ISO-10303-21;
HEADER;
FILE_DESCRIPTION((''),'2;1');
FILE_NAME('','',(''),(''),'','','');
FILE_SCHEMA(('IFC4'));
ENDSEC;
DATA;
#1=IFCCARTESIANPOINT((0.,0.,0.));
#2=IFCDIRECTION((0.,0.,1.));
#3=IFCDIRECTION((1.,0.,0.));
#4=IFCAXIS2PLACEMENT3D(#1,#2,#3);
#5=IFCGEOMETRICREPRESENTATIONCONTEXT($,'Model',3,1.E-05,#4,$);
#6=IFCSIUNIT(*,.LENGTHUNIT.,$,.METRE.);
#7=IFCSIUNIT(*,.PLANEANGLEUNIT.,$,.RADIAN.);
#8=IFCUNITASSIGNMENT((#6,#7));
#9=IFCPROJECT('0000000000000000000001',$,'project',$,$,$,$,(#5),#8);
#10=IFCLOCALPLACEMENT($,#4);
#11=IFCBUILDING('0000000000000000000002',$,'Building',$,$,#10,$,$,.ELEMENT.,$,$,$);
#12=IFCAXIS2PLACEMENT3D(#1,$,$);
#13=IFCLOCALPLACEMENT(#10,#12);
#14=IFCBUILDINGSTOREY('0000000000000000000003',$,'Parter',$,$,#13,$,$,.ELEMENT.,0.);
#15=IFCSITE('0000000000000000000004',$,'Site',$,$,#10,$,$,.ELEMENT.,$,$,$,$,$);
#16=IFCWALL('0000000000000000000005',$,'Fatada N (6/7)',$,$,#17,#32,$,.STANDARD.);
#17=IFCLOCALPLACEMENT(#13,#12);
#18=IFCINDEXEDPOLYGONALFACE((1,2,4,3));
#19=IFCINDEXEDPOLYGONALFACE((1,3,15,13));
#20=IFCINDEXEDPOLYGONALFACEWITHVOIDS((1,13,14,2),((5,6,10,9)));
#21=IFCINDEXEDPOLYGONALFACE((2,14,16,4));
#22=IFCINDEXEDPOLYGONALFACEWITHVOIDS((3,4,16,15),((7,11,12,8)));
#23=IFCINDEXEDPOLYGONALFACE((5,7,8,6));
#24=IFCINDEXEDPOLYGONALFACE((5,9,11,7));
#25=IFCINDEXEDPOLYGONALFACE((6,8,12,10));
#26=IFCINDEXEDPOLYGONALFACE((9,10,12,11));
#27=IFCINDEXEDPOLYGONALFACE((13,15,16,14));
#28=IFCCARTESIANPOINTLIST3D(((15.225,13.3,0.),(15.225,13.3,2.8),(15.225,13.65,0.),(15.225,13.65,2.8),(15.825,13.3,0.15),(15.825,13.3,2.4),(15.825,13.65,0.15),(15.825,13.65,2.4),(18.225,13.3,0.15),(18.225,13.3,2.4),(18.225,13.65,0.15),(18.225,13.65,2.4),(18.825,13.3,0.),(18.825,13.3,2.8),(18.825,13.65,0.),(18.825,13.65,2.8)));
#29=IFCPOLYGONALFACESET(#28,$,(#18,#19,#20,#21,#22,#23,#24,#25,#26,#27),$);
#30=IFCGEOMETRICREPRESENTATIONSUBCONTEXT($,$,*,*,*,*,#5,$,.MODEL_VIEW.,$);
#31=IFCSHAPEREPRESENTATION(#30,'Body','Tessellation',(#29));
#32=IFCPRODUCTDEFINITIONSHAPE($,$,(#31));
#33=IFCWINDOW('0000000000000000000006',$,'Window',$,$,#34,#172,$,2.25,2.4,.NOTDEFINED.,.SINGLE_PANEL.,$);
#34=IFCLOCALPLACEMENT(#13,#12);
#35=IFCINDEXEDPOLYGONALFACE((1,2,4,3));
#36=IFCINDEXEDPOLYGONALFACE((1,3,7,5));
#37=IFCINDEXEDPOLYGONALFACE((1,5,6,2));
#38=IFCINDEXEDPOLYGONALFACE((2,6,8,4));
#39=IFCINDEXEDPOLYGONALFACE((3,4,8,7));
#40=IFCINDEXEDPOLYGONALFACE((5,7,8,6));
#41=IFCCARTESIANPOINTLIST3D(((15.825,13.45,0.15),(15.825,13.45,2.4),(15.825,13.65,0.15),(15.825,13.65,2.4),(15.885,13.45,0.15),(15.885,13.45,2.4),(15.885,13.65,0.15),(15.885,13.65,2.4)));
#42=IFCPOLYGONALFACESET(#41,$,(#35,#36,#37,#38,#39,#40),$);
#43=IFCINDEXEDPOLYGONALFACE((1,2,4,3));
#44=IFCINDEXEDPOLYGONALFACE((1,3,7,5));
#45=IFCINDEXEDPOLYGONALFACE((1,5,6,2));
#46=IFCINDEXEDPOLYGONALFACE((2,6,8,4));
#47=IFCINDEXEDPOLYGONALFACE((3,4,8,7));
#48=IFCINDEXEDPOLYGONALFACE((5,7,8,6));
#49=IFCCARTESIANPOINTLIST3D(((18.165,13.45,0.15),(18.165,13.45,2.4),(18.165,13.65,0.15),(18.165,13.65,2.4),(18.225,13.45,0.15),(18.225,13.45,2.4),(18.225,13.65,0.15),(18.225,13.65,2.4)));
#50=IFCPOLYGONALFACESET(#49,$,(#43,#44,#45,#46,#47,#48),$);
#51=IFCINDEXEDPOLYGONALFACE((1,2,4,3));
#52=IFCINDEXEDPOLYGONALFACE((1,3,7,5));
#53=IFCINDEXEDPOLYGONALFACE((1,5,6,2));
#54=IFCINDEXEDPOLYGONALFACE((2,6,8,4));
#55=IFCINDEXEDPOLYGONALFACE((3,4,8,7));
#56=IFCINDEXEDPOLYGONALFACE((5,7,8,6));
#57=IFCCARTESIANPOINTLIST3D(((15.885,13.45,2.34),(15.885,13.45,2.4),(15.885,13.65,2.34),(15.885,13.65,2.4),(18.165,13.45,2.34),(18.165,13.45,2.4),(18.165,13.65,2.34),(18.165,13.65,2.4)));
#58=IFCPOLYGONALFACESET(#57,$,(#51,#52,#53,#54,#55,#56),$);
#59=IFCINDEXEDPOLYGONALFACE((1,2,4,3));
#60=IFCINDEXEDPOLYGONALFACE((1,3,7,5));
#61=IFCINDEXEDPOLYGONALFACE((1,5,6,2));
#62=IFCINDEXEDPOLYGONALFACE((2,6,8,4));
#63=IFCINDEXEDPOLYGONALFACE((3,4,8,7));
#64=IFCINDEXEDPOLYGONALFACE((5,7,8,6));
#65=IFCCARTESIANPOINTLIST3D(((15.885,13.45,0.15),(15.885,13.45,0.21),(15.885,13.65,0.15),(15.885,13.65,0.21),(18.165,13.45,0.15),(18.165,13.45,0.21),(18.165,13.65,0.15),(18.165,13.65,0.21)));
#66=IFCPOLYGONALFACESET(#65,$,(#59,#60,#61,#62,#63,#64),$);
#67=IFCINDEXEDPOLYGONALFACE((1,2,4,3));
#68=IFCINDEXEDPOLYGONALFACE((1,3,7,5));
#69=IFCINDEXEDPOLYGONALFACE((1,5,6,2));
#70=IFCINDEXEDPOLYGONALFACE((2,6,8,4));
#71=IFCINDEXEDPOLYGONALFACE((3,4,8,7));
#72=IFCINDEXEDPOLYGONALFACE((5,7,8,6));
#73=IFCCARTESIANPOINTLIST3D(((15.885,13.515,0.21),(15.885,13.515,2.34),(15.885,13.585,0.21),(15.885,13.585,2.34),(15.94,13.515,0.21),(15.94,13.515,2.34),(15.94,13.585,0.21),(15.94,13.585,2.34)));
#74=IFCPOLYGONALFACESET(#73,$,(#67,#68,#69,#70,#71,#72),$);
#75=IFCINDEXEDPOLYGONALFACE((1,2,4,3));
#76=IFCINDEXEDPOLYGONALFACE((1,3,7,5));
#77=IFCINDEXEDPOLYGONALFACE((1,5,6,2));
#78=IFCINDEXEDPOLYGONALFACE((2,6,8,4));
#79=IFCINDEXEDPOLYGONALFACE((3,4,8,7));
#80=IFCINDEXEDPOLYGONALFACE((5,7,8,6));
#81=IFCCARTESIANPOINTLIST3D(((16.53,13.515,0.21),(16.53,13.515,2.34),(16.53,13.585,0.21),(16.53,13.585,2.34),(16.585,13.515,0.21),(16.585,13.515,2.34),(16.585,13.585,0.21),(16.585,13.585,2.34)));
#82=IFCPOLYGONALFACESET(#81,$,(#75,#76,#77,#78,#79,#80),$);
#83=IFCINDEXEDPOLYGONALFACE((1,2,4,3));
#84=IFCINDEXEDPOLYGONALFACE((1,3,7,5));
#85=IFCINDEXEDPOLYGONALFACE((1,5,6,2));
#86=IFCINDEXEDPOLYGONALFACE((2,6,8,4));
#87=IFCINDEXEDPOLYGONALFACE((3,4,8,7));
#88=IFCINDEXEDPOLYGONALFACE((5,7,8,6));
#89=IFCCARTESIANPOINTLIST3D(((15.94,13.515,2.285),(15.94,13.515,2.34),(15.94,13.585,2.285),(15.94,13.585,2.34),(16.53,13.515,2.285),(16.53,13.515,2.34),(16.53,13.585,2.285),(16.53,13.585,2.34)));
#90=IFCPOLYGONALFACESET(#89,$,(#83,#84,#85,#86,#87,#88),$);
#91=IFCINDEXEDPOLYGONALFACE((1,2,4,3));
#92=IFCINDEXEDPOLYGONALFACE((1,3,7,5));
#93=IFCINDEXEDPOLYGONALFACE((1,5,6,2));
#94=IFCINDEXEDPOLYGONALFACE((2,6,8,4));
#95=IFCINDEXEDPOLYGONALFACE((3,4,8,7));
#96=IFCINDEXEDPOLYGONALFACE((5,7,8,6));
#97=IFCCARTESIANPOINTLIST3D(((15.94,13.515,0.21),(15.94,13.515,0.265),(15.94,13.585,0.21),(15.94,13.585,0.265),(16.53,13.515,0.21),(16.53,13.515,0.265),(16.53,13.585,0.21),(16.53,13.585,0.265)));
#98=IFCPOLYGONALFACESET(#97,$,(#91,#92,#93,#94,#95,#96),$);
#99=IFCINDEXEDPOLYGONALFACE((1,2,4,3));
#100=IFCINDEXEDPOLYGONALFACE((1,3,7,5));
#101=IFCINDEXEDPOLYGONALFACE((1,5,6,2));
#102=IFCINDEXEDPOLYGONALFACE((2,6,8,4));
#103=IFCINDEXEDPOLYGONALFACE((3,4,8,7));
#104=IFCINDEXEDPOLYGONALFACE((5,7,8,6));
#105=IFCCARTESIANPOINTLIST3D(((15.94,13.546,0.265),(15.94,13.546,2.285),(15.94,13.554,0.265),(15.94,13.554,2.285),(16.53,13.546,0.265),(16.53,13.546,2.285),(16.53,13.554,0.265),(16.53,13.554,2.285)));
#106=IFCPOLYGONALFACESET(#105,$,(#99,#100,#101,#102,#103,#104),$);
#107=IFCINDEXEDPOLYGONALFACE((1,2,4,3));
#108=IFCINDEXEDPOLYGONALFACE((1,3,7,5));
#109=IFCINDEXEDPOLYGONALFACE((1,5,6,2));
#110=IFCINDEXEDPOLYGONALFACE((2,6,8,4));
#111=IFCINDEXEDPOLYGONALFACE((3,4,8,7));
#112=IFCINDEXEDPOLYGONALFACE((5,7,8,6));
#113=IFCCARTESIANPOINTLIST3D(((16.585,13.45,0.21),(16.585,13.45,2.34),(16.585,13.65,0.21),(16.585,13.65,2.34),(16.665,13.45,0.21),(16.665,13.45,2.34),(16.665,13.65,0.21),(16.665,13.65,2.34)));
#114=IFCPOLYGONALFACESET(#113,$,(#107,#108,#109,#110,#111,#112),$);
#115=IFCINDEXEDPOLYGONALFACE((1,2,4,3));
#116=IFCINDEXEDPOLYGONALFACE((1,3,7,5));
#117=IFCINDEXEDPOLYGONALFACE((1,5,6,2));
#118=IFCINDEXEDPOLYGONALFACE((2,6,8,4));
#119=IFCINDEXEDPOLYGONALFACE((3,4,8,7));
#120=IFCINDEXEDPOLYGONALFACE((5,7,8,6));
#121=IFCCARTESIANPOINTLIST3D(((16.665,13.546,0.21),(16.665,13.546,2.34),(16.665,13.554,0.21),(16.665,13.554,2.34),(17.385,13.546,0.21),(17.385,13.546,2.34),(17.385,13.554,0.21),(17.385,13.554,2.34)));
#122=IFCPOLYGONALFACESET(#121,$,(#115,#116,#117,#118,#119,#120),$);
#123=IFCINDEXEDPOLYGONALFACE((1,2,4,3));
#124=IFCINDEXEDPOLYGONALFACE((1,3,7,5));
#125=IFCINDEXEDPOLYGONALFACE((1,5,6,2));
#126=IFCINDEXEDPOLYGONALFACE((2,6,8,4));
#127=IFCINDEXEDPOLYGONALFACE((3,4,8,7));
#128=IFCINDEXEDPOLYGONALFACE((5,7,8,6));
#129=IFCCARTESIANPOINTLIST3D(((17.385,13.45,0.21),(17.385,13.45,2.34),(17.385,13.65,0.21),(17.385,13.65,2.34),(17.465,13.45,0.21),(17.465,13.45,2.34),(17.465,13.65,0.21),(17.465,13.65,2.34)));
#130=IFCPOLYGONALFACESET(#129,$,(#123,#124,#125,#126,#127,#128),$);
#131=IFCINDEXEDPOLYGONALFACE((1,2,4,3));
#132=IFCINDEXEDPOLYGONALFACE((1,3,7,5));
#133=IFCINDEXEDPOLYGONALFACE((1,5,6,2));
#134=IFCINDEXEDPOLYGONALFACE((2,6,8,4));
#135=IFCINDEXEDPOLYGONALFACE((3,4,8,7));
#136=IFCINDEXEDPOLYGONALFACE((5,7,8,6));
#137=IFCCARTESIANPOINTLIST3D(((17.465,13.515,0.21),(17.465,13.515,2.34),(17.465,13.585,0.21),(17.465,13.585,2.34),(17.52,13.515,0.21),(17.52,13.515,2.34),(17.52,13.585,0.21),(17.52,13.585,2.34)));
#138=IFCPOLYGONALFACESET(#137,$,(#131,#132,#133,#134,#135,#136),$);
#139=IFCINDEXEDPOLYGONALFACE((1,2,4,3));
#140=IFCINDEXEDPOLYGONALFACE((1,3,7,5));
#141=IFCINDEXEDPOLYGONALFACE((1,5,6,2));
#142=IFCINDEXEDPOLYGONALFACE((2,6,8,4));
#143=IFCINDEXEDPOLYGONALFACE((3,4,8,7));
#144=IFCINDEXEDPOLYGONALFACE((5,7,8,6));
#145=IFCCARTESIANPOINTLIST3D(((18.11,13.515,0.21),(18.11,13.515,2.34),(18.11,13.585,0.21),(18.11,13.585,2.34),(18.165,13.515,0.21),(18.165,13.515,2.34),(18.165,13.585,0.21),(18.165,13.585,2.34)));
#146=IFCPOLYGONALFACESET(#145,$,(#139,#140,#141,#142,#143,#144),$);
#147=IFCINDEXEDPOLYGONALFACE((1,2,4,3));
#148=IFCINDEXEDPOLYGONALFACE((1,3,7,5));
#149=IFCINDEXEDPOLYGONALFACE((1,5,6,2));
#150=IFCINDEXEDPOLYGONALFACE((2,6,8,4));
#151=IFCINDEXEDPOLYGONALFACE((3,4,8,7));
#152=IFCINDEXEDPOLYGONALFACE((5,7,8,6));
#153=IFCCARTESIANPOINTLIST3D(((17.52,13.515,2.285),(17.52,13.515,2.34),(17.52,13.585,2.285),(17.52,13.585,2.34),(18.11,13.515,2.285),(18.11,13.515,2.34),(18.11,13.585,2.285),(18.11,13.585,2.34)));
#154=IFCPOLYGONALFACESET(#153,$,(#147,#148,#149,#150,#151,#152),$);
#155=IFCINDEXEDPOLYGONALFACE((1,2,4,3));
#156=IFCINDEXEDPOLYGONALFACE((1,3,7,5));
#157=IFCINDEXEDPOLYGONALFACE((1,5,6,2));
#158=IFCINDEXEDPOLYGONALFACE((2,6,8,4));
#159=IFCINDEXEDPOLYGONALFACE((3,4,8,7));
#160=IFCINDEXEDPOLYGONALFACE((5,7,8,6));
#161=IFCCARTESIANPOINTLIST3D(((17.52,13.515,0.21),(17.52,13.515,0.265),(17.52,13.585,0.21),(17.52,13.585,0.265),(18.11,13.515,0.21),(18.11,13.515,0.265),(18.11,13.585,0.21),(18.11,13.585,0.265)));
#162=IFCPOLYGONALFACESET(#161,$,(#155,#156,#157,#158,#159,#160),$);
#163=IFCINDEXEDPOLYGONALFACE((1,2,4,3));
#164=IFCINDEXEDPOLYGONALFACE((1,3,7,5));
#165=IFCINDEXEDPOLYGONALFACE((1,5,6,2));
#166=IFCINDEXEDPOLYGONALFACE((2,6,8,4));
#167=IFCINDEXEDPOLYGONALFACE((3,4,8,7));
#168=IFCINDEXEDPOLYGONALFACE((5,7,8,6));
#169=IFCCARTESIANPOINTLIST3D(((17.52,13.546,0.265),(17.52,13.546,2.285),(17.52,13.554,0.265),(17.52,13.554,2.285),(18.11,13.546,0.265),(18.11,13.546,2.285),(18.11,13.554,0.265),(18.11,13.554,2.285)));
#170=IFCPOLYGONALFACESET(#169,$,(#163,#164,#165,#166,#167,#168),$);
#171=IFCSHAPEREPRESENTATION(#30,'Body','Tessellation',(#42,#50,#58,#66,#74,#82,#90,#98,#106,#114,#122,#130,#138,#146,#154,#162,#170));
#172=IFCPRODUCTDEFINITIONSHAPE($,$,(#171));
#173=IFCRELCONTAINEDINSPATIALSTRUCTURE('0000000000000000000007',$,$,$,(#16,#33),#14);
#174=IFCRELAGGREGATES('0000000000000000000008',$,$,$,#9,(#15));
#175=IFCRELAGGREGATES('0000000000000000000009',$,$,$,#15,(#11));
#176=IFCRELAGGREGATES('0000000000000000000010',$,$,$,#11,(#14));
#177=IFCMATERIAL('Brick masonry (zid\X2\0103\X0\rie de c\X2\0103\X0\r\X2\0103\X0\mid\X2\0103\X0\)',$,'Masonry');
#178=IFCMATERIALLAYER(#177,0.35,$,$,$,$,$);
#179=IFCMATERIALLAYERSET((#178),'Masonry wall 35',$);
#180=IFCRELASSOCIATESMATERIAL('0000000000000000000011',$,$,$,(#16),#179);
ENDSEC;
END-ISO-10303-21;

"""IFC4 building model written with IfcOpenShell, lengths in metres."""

from ifc_helpers import new_model, si_unit, frame, frame_2d, origin, origin_with_axes, origin_2d, place, context, subcontext, project, spatial, rectangle, extrude, material, layer, layer_set, layer_usage, element, fill, save


model = new_model("IFC4")

# Units and contexts
model_context = context("Model", 3, precision=1e-05, world=origin_with_axes())
sub_context = subcontext(model_context, None, None, "MODEL_VIEW")
ifc_project = project(units=[si_unit("LENGTHUNIT", "METRE"), si_unit("PLANEANGLEUNIT", "RADIAN")], contexts=[model_context])

# Site, building, storey
placement = place(None, origin_with_axes())
site = spatial("IfcSite", under=ifc_project, at=placement, Name="Site", CompositionType="ELEMENT")
building = spatial("IfcBuilding", under=site, at=placement, Name="Building", CompositionType="ELEMENT")
storey_placement = place(placement, origin())
storey = spatial("IfcBuildingStorey", under=building, at=storey_placement, Name="Parter", CompositionType="ELEMENT", Elevation=0.0)

# Wall, opening, window
ifc_material_1 = material(Name="Brick masonry (zidărie de cărămidă)", Category="Masonry")
ifc_layer_1 = layer(ifc_material_1, 0.35)
ifc_layer_set_1 = layer_set([ifc_layer_1], Name="Masonry wall 35")
ifc_layer_usage_1 = layer_usage(ifc_layer_set_1, "AXIS2", "POSITIVE", -0.175)
wall_1_placement = place(storey_placement, frame((15.225, 13.475, 0.0), x_axis=(1.0, 0.0, 0.0)))
wall_1 = element("IfcWall", 1, at=wall_1_placement, inside=storey, material=ifc_layer_usage_1, Name="Fatada N (6/7)", PredefinedType="STANDARD", context=sub_context, shape_type="SweptSolid", body=[
    extrude(rectangle(XDim=3.6, YDim=0.35, at=frame_2d((1.8, 0.0))), origin(), (0.0, 0.0, 1.0), 2.8),
])
opening_1_placement = place(wall_1_placement, frame((1.8, 0.225, 0.15), z_axis=(0.0, -1.0, 0.0), x_axis=(1.0, 0.0, 0.0)))
opening_1 = element("IfcOpeningElement", 2, at=opening_1_placement, cuts=wall_1, PredefinedType="OPENING", context=sub_context, shape_type="SweptSolid", body=[
    extrude(rectangle(XDim=2.4, YDim=2.25, at=frame_2d((0.0, 1.125))), origin(), (0.0, 0.0, 1.0), 0.45),
])
window_1_placement = place(wall_1_placement, frame((1.8, 0.175, 0.15), z_axis=(0.0, -1.0, 0.0), x_axis=(1.0, 0.0, 0.0)))
window_1 = element("IfcWindow", 3, at=window_1_placement, inside=storey, Name="Window", OverallHeight=2.25, OverallWidth=2.4, PartitioningType="SINGLE_PANEL", PredefinedType="NOTDEFINED", context=sub_context, shape_type="SweptSolid", body=[
    extrude(rectangle(XDim=0.06, YDim=2.25, at=origin_2d()), frame((-1.17, 1.125, 0.0)), (0.0, 0.0, 1.0), 0.2),
    extrude(rectangle(XDim=0.06, YDim=2.25, at=origin_2d()), frame((1.17, 1.125, 0.0)), (0.0, 0.0, 1.0), 0.2),
    extrude(rectangle(XDim=2.28, YDim=0.06, at=origin_2d()), frame((0.0, 2.22, 0.0)), (0.0, 0.0, 1.0), 0.2),
    extrude(rectangle(XDim=2.28, YDim=0.06, at=origin_2d()), frame((0.0, 0.03, 0.0)), (0.0, 0.0, 1.0), 0.2),
    extrude(rectangle(XDim=0.055, YDim=2.13, at=origin_2d()), frame((-1.1125, 1.125, 0.065)), (0.0, 0.0, 1.0), 0.07),
    extrude(rectangle(XDim=0.055, YDim=2.13, at=origin_2d()), frame((-0.4675, 1.125, 0.065)), (0.0, 0.0, 1.0), 0.07),
    extrude(rectangle(XDim=0.59, YDim=0.055, at=origin_2d()), frame((-0.79, 2.1625, 0.065)), (0.0, 0.0, 1.0), 0.07),
    extrude(rectangle(XDim=0.59, YDim=0.055, at=origin_2d()), frame((-0.79, 0.0875, 0.065)), (0.0, 0.0, 1.0), 0.07),
    extrude(rectangle(XDim=0.59, YDim=2.02, at=origin_2d()), frame((-0.79, 1.125, 0.096)), (0.0, 0.0, 1.0), 0.008),
    extrude(rectangle(XDim=0.08, YDim=2.13, at=origin_2d()), frame((-0.4, 1.125, 0.0)), (0.0, 0.0, 1.0), 0.2),
    extrude(rectangle(XDim=0.72, YDim=2.13, at=origin_2d()), frame((0.0, 1.125, 0.096)), (0.0, 0.0, 1.0), 0.008),
    extrude(rectangle(XDim=0.08, YDim=2.13, at=origin_2d()), frame((0.4, 1.125, 0.0)), (0.0, 0.0, 1.0), 0.2),
    extrude(rectangle(XDim=0.055, YDim=2.13, at=origin_2d()), frame((0.4675, 1.125, 0.065)), (0.0, 0.0, 1.0), 0.07),
    extrude(rectangle(XDim=0.055, YDim=2.13, at=origin_2d()), frame((1.1125, 1.125, 0.065)), (0.0, 0.0, 1.0), 0.07),
    extrude(rectangle(XDim=0.59, YDim=0.055, at=origin_2d()), frame((0.79, 2.1625, 0.065)), (0.0, 0.0, 1.0), 0.07),
    extrude(rectangle(XDim=0.59, YDim=0.055, at=origin_2d()), frame((0.79, 0.0875, 0.065)), (0.0, 0.0, 1.0), 0.07),
    extrude(rectangle(XDim=0.59, YDim=2.02, at=origin_2d()), frame((0.79, 1.125, 0.096)), (0.0, 0.0, 1.0), 0.008),
])
fill(opening_1, window_1)

save(model, "model.ifc")
